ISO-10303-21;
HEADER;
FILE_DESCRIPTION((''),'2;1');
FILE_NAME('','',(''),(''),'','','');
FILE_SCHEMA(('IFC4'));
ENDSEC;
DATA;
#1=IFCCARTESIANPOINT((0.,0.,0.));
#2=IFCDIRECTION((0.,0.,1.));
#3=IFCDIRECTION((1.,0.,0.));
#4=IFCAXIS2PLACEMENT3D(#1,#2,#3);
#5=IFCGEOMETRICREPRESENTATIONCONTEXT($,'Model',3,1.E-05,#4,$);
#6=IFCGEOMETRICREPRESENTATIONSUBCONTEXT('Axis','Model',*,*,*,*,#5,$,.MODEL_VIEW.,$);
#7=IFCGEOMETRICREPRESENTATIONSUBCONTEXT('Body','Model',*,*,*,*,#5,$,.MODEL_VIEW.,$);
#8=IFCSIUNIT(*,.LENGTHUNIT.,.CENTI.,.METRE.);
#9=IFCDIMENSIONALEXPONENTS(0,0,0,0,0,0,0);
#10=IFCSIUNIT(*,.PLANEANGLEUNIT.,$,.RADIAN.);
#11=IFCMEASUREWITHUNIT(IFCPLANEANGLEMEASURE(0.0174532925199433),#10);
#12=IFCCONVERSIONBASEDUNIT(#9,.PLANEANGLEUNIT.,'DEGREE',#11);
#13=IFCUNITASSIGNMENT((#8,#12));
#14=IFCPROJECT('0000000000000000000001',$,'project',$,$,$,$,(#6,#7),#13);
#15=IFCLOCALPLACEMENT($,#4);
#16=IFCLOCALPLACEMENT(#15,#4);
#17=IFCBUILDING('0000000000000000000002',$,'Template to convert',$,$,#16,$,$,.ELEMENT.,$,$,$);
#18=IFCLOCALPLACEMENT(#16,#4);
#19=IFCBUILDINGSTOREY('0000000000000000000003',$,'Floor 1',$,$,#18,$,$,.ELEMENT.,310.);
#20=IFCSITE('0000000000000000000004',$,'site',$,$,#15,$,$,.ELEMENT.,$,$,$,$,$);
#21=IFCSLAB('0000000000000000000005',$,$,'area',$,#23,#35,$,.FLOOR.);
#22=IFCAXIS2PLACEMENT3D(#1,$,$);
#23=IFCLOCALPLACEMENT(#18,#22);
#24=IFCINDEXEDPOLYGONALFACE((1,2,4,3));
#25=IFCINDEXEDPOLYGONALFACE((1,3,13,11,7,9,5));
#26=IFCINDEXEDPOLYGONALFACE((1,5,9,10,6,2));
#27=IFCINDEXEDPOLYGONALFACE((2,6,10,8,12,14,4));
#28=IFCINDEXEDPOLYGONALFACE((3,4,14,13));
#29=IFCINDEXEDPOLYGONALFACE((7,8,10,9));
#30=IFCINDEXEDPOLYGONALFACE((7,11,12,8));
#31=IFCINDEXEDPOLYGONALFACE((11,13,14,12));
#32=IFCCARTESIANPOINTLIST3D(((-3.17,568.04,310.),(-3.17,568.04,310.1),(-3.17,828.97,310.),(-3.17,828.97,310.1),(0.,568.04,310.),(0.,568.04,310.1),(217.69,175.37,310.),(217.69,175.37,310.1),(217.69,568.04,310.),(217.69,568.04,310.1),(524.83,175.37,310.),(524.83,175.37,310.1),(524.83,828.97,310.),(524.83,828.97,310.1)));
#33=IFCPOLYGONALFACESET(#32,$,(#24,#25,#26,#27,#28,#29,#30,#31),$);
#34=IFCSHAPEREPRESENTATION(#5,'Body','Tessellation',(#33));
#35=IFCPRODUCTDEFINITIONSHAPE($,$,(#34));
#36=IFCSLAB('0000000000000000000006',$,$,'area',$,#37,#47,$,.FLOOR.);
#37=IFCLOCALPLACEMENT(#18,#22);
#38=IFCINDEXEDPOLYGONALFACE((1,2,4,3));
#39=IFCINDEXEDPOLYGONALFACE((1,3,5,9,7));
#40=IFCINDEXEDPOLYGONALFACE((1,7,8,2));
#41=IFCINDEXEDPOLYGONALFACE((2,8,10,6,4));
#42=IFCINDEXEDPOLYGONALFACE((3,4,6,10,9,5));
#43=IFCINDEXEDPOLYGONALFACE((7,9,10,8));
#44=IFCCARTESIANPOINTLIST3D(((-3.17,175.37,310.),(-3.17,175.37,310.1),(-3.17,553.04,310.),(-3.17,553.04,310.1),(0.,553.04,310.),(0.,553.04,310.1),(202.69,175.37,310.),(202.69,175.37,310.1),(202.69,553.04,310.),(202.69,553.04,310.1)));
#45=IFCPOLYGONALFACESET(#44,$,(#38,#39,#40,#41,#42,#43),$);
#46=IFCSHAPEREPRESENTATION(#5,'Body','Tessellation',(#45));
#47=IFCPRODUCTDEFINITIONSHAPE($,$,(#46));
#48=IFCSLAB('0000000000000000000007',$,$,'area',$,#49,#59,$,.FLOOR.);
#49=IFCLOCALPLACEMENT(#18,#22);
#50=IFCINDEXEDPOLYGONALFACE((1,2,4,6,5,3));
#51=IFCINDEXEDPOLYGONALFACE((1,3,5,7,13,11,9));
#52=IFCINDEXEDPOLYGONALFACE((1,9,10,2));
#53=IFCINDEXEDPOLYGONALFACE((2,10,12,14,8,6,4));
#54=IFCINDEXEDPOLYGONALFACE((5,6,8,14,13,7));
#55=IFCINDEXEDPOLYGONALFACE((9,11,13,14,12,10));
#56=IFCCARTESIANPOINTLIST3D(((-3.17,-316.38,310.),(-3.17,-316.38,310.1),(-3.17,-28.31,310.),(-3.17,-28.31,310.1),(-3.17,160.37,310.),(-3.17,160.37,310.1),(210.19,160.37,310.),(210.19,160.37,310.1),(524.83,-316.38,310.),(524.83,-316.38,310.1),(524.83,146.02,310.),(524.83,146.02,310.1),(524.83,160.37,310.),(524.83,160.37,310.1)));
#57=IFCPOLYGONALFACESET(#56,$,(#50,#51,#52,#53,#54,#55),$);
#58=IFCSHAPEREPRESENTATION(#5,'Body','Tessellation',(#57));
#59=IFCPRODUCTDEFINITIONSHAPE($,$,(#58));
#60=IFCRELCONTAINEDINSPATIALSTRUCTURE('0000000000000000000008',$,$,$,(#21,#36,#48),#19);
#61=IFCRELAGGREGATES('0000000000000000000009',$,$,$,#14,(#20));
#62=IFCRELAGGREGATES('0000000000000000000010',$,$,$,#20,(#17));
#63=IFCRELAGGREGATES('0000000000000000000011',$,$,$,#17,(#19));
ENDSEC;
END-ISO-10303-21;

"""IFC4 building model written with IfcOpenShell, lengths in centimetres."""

from ifc_helpers import new_model, entity, si_unit, converted_unit, frame, origin_with_axes, place, context, subcontext, project, spatial, polyline, outline, extrude, element, save


model = new_model("IFC4")

# Units and contexts
model_context = context("Model", 3, precision=1e-05, world=origin_with_axes())
body_context = subcontext(model_context, "Body", "Model", "MODEL_VIEW")
axis_context = subcontext(model_context, "Axis", "Model", "MODEL_VIEW")
ifc_project = project(units=[si_unit("LENGTHUNIT", "METRE", prefix="CENTI"), converted_unit("PLANEANGLEUNIT", "DEGREE", entity("IfcPlaneAngleMeasure", 0.0174532925199433), si_unit("PLANEANGLEUNIT", "RADIAN"), dimensions=[0, 0, 0, 0, 0, 0, 0])], contexts=[axis_context, body_context])

# Site, building, storey
site_placement = place(None, origin_with_axes())
site = spatial("IfcSite", under=ifc_project, at=site_placement, Name="site", CompositionType="ELEMENT")
building_placement = place(site_placement, origin_with_axes())
building = spatial("IfcBuilding", under=site, at=building_placement, Name="Template to convert", CompositionType="ELEMENT")
storey_placement = place(building_placement, origin_with_axes())
storey = spatial("IfcBuildingStorey", under=building, at=storey_placement, Name="Floor 1", CompositionType="ELEMENT", Elevation=310.0)

# Slabs
slab_1_placement = place(storey_placement, frame((0.0, 0.0, 310.0), z_axis=(0.0, 0.0, 1.0), x_axis=(1.0, 0.0, 0.0)))
element("IfcSlab", 1, at=slab_1_placement, inside=storey, Description="area", PredefinedType="FLOOR", context=model_context, shape_type="SweptSolid", body=[
    extrude(outline(polyline([(-3.17, 828.97, 0.0), (-3.17, 568.04, 0.0), (0.0, 568.04, 0.0), (217.69, 568.04, 0.0), (217.69, 175.37, 0.0), (524.83, 175.37, 0.0), (524.83, 828.97, 0.0), (-3.17, 828.97, 0.0), (-3.17, 828.97, 0.0)])), origin_with_axes(), (0.0, 0.0, 1.0), 0.1),
])
slab_2_placement = place(storey_placement, frame((0.0, 0.0, 310.0), z_axis=(0.0, 0.0, 1.0), x_axis=(1.0, 0.0, 0.0)))
element("IfcSlab", 2, at=slab_2_placement, inside=storey, Description="area", PredefinedType="FLOOR", context=model_context, shape_type="SweptSolid", body=[
    extrude(outline(polyline([(-3.17, 553.04, 0.0), (-3.17, 175.37, 0.0), (202.69, 175.37, 0.0), (202.69, 553.04, 0.0), (0.0, 553.04, 0.0), (-3.17, 553.04, 0.0), (-3.17, 553.04, 0.0)])), origin_with_axes(), (0.0, 0.0, 1.0), 0.1),
])
slab_3_placement = place(storey_placement, frame((0.0, 0.0, 310.0), z_axis=(0.0, 0.0, 1.0), x_axis=(1.0, 0.0, 0.0)))
element("IfcSlab", 3, at=slab_3_placement, inside=storey, Description="area", PredefinedType="FLOOR", context=model_context, shape_type="SweptSolid", body=[
    extrude(outline(polyline([(-3.17, 160.37, 0.0), (-3.17, -28.31, 0.0), (-3.17, -316.38, 0.0), (524.83, -316.38, 0.0), (524.83, 146.02, 0.0), (524.83, 160.37, 0.0), (210.19, 160.37, 0.0), (-3.17, 160.37, 0.0), (-3.17, 160.37, 0.0)])), origin_with_axes(), (0.0, 0.0, 1.0), 0.1),
])

save(model, "model.ifc")
